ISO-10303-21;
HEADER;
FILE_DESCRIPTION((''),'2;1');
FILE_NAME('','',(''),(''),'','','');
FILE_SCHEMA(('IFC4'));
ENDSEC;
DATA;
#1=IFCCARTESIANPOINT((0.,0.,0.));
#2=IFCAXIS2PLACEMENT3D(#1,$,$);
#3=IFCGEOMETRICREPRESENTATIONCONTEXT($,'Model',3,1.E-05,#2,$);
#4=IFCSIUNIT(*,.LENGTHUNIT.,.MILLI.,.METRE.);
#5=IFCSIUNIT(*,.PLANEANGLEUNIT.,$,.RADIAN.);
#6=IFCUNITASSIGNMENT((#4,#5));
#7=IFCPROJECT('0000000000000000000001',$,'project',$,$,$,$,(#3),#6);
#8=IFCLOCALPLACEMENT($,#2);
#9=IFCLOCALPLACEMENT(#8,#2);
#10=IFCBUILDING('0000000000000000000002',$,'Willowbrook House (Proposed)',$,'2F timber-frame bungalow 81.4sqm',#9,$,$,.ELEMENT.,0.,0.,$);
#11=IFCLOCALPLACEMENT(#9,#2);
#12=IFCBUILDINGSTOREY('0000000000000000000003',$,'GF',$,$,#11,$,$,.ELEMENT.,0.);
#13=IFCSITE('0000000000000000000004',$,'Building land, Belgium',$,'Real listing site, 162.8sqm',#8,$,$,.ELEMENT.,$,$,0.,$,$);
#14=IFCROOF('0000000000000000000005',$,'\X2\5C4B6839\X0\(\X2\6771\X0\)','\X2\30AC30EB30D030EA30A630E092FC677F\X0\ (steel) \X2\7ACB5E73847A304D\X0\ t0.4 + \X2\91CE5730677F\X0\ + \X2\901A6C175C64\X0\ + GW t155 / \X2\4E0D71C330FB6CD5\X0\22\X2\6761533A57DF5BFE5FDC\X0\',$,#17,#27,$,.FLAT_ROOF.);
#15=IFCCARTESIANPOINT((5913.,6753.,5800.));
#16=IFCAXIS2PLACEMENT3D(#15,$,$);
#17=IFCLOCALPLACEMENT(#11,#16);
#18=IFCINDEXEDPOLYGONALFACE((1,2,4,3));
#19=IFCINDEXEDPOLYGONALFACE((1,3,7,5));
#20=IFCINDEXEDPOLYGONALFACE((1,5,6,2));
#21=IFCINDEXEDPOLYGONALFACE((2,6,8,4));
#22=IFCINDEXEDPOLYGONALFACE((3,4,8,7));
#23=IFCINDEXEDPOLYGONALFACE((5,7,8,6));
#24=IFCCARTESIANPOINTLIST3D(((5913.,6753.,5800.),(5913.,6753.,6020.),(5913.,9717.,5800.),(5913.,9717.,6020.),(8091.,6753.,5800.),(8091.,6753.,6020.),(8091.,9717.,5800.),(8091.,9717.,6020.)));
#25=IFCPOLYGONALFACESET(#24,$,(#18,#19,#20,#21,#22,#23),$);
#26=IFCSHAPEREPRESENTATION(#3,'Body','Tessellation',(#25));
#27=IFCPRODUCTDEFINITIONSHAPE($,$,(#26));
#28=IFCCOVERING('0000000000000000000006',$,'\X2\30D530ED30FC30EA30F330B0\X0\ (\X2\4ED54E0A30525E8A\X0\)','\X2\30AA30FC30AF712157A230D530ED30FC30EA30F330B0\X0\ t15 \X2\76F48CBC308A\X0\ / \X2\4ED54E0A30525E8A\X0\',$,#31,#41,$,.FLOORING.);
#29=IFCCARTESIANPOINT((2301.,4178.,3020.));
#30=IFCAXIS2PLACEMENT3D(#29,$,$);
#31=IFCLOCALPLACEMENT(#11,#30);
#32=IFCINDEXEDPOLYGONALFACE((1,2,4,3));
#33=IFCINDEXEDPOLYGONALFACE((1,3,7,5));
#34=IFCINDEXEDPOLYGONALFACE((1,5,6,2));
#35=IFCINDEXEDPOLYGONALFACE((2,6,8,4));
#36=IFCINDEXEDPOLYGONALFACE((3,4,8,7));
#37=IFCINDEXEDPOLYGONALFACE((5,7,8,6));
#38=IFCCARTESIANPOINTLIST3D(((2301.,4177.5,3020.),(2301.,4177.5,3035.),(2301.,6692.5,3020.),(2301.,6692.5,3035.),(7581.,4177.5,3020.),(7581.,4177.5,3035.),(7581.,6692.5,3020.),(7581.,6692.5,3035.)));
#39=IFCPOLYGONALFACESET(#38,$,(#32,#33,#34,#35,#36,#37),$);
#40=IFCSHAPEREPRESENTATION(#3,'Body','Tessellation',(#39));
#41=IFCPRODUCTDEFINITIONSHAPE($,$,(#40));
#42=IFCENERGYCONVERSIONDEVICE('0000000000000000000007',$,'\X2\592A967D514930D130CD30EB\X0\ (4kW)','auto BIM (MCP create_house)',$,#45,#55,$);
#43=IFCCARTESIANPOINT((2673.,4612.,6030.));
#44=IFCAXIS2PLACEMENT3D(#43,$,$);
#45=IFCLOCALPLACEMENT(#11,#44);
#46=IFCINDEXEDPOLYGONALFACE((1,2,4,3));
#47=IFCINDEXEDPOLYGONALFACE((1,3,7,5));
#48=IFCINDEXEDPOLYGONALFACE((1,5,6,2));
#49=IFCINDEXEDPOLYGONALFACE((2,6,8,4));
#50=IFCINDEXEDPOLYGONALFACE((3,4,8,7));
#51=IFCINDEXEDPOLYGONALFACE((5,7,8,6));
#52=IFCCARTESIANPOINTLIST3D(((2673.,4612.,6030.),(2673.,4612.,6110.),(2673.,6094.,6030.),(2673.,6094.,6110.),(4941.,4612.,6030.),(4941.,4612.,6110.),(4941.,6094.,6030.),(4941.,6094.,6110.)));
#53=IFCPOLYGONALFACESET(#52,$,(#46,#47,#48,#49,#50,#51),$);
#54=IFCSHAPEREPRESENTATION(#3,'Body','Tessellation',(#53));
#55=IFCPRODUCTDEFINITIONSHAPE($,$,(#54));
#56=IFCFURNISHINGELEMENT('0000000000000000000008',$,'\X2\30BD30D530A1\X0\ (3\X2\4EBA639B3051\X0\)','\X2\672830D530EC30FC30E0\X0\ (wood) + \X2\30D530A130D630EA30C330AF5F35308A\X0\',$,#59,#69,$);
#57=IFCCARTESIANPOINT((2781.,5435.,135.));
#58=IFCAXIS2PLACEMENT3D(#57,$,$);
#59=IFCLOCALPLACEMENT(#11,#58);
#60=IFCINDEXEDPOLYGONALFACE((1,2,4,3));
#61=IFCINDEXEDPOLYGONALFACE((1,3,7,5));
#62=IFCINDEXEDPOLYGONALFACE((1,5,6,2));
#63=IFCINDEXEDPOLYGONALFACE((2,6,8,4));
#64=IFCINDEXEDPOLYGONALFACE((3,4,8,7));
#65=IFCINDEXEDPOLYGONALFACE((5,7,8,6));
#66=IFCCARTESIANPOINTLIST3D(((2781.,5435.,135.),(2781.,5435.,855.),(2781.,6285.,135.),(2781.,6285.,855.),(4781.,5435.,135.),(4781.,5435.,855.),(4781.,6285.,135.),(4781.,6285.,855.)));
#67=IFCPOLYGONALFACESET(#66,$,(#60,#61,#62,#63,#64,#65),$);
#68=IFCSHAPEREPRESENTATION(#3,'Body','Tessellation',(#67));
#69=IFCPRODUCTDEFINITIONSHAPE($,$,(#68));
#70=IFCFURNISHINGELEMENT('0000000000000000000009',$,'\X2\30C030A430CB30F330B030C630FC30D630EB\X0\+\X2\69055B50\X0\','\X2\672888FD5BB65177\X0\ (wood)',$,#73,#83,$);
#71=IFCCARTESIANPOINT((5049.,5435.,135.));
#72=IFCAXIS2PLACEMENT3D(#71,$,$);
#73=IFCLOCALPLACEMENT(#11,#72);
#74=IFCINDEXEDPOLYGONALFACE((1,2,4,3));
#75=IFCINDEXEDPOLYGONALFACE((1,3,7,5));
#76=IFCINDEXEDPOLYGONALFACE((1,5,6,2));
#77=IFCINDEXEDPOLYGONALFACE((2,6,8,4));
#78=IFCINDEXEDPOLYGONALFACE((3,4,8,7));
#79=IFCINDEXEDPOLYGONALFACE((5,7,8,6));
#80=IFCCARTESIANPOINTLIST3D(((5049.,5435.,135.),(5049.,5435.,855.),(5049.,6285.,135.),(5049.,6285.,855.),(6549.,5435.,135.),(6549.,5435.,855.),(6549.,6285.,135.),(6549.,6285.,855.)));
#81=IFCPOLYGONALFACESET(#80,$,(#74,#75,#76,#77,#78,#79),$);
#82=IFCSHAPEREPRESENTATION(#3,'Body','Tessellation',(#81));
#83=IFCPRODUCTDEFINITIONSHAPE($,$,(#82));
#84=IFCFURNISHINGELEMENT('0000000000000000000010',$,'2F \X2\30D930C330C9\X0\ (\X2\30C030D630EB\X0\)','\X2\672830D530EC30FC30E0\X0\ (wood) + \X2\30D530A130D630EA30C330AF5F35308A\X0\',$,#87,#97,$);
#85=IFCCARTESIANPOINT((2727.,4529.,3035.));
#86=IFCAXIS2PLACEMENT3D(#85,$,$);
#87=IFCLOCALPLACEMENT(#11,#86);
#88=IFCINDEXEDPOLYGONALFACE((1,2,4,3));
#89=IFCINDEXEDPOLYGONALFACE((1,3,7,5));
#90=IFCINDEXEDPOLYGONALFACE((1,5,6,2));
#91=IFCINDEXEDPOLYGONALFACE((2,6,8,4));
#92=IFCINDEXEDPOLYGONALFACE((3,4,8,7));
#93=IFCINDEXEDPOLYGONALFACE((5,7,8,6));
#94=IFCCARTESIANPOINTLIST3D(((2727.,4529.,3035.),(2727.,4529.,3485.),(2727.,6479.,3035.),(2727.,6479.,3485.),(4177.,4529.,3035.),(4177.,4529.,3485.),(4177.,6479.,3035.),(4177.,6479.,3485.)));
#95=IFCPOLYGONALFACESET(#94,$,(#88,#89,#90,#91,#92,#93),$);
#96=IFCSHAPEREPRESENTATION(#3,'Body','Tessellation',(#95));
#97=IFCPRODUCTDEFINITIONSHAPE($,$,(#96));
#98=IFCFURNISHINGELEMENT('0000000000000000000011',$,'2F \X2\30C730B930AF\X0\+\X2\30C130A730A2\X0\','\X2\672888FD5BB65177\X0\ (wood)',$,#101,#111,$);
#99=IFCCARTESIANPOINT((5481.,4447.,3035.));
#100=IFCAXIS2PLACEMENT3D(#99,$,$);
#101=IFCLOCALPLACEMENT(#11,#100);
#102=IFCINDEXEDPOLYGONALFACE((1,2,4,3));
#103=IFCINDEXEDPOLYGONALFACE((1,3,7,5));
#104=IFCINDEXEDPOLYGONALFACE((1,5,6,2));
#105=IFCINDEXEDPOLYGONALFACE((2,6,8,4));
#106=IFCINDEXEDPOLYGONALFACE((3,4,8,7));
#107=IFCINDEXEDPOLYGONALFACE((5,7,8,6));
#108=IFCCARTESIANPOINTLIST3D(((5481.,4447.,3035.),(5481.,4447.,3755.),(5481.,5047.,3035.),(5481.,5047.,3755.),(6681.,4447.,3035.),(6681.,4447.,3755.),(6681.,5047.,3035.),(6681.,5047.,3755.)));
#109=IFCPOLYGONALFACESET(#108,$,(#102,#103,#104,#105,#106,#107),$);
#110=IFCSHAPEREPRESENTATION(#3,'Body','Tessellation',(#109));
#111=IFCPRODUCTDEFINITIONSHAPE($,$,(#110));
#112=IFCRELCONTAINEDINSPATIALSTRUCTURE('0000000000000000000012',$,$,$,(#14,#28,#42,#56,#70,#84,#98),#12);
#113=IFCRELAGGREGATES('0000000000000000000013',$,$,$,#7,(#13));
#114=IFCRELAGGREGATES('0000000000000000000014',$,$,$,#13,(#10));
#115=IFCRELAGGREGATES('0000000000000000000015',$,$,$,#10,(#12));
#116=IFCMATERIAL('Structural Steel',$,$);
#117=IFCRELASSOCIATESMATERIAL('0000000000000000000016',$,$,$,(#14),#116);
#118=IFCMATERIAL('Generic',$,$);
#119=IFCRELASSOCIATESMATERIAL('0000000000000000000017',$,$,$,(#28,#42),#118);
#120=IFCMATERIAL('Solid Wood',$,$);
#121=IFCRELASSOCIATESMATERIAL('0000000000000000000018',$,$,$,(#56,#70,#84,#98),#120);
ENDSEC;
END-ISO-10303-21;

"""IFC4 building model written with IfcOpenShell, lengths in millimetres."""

from ifc_helpers import new_model, si_unit, frame, frame_2d, origin, place, context, project, spatial, rectangle, extrude, material, element, save


model = new_model("IFC4")

# Units and contexts
model_context = context("Model", 3, precision=1e-05, world=origin())
ifc_project = project(units=[si_unit("LENGTHUNIT", "METRE", prefix="MILLI"), si_unit("PLANEANGLEUNIT", "RADIAN")], contexts=[model_context])

# Site, building, storey
site_placement = place(None, origin())
site = spatial("IfcSite", under=ifc_project, at=site_placement, Name="Building land, Belgium", ObjectType="Real listing site, 162.8sqm", CompositionType="ELEMENT", RefElevation=0.0)
building_placement = place(site_placement, origin())
building = spatial("IfcBuilding", under=site, at=building_placement, Name="Willowbrook House (Proposed)", ObjectType="2F timber-frame bungalow 81.4sqm", CompositionType="ELEMENT", ElevationOfRefHeight=0.0, ElevationOfTerrain=0.0)
storey_placement = place(building_placement, origin())
storey = spatial("IfcBuildingStorey", under=building, at=storey_placement, Name="GF", CompositionType="ELEMENT", Elevation=0.0)

# Shared definitions
ifc_material_1 = material(Name="Solid Wood")

# Roof
ifc_material_2 = material(Name="Structural Steel")
roof_1_placement = place(storey_placement, frame((5913.0, 6753.0, 5800.0)))
element("IfcRoof", 1, at=roof_1_placement, inside=storey, material=ifc_material_2, Name="屋根(東)", Description="ガルバリウム鋼板 (steel) 立平葺き t0.4 + 野地板 + 通気層 + GW t155 / 不燃・法22条区域対応", PredefinedType="FLAT_ROOF", context=model_context, shape_type="SweptSolid", body=[
    extrude(rectangle(XDim=2178.0, YDim=2964.0, at=frame_2d((1089.0, 1482.0))), frame((5913.0, 6753.0, 5800.0)), (0.0, 0.0, 1.0), 220.0),
])

# Covering
ifc_material_3 = material(Name="Generic")
covering_placement = place(storey_placement, frame((2301.0, 4178.0, 3020.0)))
element("IfcCovering", 2, at=covering_placement, inside=storey, material=ifc_material_3, Name="フローリング (仕上げ床)", Description="オーク無垢フローリング t15 直貼り / 仕上げ床", PredefinedType="FLOORING", context=model_context, shape_type="SweptSolid", body=[
    extrude(rectangle(XDim=5280.0, YDim=2515.0, at=frame_2d((2640.0, 1257.0))), frame((2301.0, 4178.0, 3020.0)), (0.0, 0.0, 1.0), 15.0),
])

# Energy conversion device
energy_conversion_device_placement = place(storey_placement, frame((2673.0, 4612.0, 6030.0)))
element("IfcEnergyConversionDevice", 3, at=energy_conversion_device_placement, inside=storey, material=ifc_material_3, Name="太陽光パネル (4kW)", Description="auto BIM (MCP create_house)", context=model_context, shape_type="SweptSolid", body=[
    extrude(rectangle(XDim=2268.0, YDim=1482.0, at=frame_2d((1134.0, 741.0))), frame((2673.0, 4612.0, 6030.0)), (0.0, 0.0, 1.0), 80.0),
])

# Furnishing elements
furnishing_1_placement = place(storey_placement, frame((2781.0, 5435.0, 135.0)))
element("IfcFurnishingElement", 4, at=furnishing_1_placement, inside=storey, material=ifc_material_1, Name="ソファ (3人掛け)", Description="木フレーム (wood) + ファブリック張り", context=model_context, shape_type="SweptSolid", body=[
    extrude(rectangle(XDim=2000.0, YDim=850.0, at=frame_2d((1000.0, 425.0))), frame((2781.0, 5435.0, 135.0)), (0.0, 0.0, 1.0), 720.0),
])
furnishing_2_placement = place(storey_placement, frame((5049.0, 5435.0, 135.0)))
element("IfcFurnishingElement", 5, at=furnishing_2_placement, inside=storey, material=ifc_material_1, Name="ダイニングテーブル+椅子", Description="木製家具 (wood)", context=model_context, shape_type="SweptSolid", body=[
    extrude(rectangle(XDim=1500.0, YDim=850.0, at=frame_2d((750.0, 425.0))), frame((5049.0, 5435.0, 135.0)), (0.0, 0.0, 1.0), 720.0),
])
furnishing_3_placement = place(storey_placement, frame((2727.0, 4529.0, 3035.0)))
element("IfcFurnishingElement", 6, at=furnishing_3_placement, inside=storey, material=ifc_material_1, Name="2F ベッド (ダブル)", Description="木フレーム (wood) + ファブリック張り", context=model_context, shape_type="SweptSolid", body=[
    extrude(rectangle(XDim=1450.0, YDim=1950.0, at=frame_2d((725.0, 975.0))), frame((2727.0, 4529.0, 3035.0)), (0.0, 0.0, 1.0), 450.0),
])
furnishing_4_placement = place(storey_placement, frame((5481.0, 4447.0, 3035.0)))
element("IfcFurnishingElement", 7, at=furnishing_4_placement, inside=storey, material=ifc_material_1, Name="2F デスク+チェア", Description="木製家具 (wood)", context=model_context, shape_type="SweptSolid", body=[
    extrude(rectangle(XDim=1200.0, YDim=600.0, at=frame_2d((600.0, 300.0))), frame((5481.0, 4447.0, 3035.0)), (0.0, 0.0, 1.0), 720.0),
])

save(model, "model.ifc")
